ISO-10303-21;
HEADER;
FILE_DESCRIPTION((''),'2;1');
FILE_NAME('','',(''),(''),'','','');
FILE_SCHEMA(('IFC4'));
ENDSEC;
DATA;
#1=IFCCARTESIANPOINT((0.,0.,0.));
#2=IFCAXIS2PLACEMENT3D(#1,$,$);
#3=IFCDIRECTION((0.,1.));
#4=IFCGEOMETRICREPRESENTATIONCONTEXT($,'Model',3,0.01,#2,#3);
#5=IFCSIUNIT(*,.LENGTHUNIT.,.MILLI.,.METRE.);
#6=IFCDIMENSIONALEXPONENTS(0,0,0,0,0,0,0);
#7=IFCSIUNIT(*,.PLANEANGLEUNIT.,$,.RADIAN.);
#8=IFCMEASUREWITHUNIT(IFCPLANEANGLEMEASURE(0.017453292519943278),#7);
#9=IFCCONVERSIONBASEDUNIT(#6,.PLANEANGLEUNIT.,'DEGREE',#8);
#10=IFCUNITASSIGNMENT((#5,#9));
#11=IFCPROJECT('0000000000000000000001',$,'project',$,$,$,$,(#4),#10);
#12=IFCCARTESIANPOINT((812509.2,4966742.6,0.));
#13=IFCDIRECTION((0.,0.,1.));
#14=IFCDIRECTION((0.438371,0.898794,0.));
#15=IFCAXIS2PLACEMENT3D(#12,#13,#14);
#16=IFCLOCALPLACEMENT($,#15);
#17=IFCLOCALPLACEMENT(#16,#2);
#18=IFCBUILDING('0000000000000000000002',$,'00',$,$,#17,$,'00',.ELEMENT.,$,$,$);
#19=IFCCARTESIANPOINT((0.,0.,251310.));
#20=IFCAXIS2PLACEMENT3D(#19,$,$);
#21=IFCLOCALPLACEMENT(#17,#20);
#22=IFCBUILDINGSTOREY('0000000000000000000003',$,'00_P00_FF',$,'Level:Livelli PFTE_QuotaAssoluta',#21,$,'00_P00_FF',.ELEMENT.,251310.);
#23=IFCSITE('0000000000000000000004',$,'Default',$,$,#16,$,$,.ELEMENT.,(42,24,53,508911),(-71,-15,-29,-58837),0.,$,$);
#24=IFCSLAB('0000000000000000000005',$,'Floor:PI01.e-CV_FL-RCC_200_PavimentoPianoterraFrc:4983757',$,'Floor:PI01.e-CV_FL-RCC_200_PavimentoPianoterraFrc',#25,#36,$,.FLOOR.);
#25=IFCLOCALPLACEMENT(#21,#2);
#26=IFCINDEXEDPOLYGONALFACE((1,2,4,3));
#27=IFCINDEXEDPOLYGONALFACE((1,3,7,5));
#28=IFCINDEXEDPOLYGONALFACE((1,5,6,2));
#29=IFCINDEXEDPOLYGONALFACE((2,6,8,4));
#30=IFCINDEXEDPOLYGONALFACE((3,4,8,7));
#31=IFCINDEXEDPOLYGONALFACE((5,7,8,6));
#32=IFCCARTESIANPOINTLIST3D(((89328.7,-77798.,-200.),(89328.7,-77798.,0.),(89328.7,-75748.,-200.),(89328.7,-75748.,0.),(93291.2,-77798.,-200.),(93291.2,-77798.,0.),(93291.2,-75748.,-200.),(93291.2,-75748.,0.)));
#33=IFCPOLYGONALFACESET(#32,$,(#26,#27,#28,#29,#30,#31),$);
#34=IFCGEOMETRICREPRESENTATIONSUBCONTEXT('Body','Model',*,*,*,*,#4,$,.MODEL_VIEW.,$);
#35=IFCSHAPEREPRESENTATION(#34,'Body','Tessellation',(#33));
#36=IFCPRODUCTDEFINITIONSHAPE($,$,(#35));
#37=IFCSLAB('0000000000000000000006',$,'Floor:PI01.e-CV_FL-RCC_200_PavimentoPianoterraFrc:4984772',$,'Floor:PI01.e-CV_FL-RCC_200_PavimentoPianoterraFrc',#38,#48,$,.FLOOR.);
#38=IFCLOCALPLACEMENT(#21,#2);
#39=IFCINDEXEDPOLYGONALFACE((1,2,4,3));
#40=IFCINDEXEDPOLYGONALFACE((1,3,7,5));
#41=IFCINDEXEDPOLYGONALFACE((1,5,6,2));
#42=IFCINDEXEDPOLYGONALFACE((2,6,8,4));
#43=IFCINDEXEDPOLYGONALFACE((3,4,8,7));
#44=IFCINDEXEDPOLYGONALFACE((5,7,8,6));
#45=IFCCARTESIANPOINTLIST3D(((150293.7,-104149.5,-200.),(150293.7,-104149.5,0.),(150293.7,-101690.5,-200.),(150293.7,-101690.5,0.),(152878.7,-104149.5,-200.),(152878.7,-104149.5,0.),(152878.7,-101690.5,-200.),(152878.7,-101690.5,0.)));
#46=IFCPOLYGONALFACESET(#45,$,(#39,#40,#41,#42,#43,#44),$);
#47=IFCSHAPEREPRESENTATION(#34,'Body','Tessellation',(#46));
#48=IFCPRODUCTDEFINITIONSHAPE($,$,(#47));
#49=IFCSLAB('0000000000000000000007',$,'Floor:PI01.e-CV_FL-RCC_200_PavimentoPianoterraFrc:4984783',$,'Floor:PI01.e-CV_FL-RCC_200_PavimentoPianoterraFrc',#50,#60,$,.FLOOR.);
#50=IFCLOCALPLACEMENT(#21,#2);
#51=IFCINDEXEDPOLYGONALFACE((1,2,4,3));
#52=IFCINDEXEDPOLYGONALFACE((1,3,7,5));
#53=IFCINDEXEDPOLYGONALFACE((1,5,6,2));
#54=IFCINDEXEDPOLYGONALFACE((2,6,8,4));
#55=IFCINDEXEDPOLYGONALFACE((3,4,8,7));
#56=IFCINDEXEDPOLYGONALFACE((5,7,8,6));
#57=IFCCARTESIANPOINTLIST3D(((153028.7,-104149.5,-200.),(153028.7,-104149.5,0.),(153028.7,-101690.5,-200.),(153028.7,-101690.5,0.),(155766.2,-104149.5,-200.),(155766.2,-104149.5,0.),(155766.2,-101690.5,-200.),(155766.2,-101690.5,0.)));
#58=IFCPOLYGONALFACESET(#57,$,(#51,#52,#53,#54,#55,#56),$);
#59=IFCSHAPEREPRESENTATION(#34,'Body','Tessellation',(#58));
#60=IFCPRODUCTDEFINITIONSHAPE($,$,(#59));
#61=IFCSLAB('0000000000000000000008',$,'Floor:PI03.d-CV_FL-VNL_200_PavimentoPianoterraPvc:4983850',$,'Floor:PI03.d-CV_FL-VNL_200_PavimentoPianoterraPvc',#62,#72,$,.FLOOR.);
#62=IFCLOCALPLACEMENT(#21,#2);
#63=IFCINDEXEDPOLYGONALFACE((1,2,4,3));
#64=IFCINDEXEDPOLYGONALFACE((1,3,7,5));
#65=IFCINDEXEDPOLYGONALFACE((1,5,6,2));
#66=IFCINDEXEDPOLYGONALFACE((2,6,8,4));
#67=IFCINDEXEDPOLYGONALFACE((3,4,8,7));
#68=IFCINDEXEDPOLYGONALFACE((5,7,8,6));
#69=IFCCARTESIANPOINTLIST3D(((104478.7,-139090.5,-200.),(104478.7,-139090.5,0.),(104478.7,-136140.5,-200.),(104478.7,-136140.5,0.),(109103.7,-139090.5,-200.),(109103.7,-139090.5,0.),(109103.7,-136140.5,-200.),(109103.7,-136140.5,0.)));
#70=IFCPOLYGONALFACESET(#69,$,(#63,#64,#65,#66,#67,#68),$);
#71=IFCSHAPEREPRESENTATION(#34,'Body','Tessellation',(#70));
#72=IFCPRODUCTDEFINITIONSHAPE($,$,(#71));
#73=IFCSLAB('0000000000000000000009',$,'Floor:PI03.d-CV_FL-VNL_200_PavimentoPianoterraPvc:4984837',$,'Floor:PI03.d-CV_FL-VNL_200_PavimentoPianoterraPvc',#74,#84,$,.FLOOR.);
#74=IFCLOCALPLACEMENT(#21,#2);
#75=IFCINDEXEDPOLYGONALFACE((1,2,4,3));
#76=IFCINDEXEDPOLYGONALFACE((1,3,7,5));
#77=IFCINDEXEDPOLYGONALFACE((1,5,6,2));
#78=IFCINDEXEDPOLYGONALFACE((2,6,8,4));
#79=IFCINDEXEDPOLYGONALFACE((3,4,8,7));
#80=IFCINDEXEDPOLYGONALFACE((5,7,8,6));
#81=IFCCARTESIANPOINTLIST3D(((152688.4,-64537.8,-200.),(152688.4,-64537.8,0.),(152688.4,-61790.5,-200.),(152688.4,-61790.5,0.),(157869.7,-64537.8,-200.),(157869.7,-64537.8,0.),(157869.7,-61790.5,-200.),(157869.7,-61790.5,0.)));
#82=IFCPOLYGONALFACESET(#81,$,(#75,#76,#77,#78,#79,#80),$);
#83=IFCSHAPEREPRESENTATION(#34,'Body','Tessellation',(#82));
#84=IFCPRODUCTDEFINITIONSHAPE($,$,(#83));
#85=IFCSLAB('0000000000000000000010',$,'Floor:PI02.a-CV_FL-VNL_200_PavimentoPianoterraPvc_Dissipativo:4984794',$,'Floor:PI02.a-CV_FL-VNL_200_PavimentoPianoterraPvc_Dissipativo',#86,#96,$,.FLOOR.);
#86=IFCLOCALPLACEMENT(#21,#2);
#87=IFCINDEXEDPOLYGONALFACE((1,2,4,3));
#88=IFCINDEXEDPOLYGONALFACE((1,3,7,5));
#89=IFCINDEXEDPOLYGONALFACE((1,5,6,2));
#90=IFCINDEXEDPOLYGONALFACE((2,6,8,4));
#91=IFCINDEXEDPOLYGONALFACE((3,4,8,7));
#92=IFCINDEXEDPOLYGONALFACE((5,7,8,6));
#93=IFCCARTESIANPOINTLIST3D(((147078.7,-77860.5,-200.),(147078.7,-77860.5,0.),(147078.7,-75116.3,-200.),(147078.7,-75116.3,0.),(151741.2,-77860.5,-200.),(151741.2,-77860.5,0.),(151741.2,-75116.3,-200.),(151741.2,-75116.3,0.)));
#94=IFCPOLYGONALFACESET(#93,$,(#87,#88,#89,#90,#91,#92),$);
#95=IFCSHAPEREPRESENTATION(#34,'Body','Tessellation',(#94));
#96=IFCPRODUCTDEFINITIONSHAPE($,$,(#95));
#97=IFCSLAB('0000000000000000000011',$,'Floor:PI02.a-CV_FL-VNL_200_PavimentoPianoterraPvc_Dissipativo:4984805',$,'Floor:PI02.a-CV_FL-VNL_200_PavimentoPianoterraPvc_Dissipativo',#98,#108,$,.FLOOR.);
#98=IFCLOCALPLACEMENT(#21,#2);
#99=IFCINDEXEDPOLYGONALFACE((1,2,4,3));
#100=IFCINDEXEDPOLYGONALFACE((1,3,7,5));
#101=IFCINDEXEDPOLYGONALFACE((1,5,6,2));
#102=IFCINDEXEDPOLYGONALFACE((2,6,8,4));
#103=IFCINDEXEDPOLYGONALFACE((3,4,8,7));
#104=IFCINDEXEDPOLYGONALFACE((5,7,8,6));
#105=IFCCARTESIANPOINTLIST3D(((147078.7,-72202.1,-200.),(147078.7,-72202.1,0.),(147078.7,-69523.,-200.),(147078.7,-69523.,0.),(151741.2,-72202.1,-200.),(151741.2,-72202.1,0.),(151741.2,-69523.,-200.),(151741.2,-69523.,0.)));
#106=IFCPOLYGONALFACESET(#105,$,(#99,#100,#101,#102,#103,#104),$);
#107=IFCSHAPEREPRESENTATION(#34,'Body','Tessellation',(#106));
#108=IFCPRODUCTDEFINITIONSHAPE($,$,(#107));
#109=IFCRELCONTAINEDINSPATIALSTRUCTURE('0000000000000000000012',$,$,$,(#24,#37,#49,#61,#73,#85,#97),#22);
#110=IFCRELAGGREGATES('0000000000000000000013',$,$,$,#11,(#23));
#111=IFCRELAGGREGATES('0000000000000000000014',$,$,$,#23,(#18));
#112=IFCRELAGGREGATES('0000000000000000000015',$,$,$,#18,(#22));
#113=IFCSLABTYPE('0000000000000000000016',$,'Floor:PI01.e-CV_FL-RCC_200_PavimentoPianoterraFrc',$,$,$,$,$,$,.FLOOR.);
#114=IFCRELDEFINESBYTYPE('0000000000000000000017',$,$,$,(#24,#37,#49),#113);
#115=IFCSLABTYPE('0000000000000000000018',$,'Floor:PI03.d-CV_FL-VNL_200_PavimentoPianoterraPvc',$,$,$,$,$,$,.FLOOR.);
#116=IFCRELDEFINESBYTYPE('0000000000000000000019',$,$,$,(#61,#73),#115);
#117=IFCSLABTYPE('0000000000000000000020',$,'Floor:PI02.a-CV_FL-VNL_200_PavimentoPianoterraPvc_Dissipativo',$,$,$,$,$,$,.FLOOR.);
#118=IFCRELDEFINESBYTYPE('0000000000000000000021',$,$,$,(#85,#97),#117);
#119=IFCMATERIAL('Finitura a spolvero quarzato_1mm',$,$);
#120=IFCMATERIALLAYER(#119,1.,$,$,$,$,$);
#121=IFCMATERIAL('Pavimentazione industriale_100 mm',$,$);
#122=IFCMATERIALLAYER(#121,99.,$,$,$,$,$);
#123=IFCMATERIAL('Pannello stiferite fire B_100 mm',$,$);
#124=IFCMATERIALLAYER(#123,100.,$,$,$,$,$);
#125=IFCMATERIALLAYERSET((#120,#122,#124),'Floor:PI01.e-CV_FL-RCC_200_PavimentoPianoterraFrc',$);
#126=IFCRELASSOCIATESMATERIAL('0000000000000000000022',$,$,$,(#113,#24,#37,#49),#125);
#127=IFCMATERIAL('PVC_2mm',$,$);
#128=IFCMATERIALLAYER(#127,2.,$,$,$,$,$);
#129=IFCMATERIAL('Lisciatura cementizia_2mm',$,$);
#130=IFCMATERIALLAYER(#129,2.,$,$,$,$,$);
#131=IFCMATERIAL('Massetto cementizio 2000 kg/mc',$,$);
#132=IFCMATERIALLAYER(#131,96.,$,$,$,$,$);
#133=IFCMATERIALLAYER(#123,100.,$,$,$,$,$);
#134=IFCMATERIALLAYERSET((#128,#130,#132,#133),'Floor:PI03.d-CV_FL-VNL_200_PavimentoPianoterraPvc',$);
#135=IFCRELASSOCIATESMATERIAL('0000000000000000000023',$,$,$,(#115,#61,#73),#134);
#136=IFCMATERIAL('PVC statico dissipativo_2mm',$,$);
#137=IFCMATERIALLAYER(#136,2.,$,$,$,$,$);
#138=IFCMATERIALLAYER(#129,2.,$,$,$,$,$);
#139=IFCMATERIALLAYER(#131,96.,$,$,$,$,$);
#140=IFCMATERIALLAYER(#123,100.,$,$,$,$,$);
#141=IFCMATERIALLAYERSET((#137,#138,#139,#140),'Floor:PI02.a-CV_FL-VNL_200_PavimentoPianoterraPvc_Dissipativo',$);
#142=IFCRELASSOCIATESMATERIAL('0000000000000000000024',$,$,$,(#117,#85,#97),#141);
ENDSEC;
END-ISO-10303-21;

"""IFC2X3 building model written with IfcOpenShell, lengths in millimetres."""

from ifc_helpers import new_model, entity, si_unit, converted_unit, direction, frame, frame_2d, origin, origin_2d_with_axis, place, context, subcontext, project, spatial, rectangle, extrude, material, layer, layer_set, layer_usage, type_object, element, save


model = new_model("IFC2X3")

# Units and contexts
model_context = context("Model", 3, precision=0.01, world=origin(), true_north=direction((0.0, 1.0)))
body_context = subcontext(model_context, "Body", "Model", "MODEL_VIEW")
ifc_project = project(units=[si_unit("LENGTHUNIT", "METRE", prefix="MILLI"), converted_unit("PLANEANGLEUNIT", "DEGREE", entity("IfcPlaneAngleMeasure", 0.017453292519943278), si_unit("PLANEANGLEUNIT", "RADIAN"), dimensions=[0, 0, 0, 0, 0, 0, 0])], contexts=[model_context])

# Site, building, storey
site_placement = place(None, frame((812509.2, 4966742.6, 0.0), z_axis=(0.0, 0.0, 1.0), x_axis=(0.438371, 0.898794, 0.0)))
site = spatial("IfcSite", under=ifc_project, at=site_placement, Name="Default", CompositionType="ELEMENT", RefLatitude=(42, 24, 53, 508911), RefLongitude=(-71, -15, -29, -58837), RefElevation=0.0)
building_placement = place(site_placement, origin())
building = spatial("IfcBuilding", under=site, at=building_placement, Name="00", LongName="00", CompositionType="ELEMENT")
storey_placement = place(building_placement, frame((0.0, 0.0, 251310.0)))
storey = spatial("IfcBuildingStorey", under=building, at=storey_placement, Name="00_P00_FF", ObjectType="Level:Livelli PFTE_QuotaAssoluta", LongName="00_P00_FF", CompositionType="ELEMENT", Elevation=251310.0)

# Slabs
ifc_material_1 = material(Name="Massetto cementizio 2000 kg/mc")
ifc_material_2 = material(Name="Pannello stiferite fire B_100 mm")
ifc_material_3 = material(Name="Finitura a spolvero quarzato_1mm")
ifc_layer_1 = layer(ifc_material_3, 1.0)
ifc_material_4 = material(Name="Pavimentazione industriale_100 mm")
ifc_layer_2 = layer(ifc_material_4, 99.0)
ifc_layer_3 = layer(ifc_material_2, 100.0)
ifc_layer_set_1 = layer_set([ifc_layer_1, ifc_layer_2, ifc_layer_3], Name="Floor:PI01.e-CV_FL-RCC_200_PavimentoPianoterraFrc")
ifc_layer_usage_1 = layer_usage(ifc_layer_set_1, "AXIS3", "POSITIVE", 0.0)
slab_type_1 = type_object("IfcSlabType", Name="Floor:PI01.e-CV_FL-RCC_200_PavimentoPianoterraFrc", PredefinedType="FLOOR", material=ifc_layer_set_1)
slab_1_placement = place(storey_placement, origin())
element("IfcSlab", 1, at=slab_1_placement, inside=storey, type_object=slab_type_1, material=ifc_layer_usage_1, Name="Floor:PI01.e-CV_FL-RCC_200_PavimentoPianoterraFrc:4983757", ObjectType="Floor:PI01.e-CV_FL-RCC_200_PavimentoPianoterraFrc", PredefinedType="FLOOR", context=body_context, shape_type="SweptSolid", body=[
    extrude(rectangle(XDim=2050.0, YDim=3962.5, at=frame_2d((0.0, 0.0), x_axis=(1.0, 0.0))), frame((91309.9, -76773.0, 0.0), z_axis=(0.0, 0.0, -1.0), x_axis=(0.0, 1.0, 0.0)), (0.0, 0.0, 1.0), 200.0),
])
ifc_layer_usage_2 = layer_usage(ifc_layer_set_1, "AXIS3", "POSITIVE", 0.0)
slab_2_placement = place(storey_placement, origin())
element("IfcSlab", 2, at=slab_2_placement, inside=storey, type_object=slab_type_1, material=ifc_layer_usage_2, Name="Floor:PI01.e-CV_FL-RCC_200_PavimentoPianoterraFrc:4984772", ObjectType="Floor:PI01.e-CV_FL-RCC_200_PavimentoPianoterraFrc", PredefinedType="FLOOR", context=body_context, shape_type="SweptSolid", body=[
    extrude(rectangle(XDim=2459.0, YDim=2585.0, at=frame_2d((0.0, 0.0), x_axis=(1.0, 0.0))), frame((151586.2, -102920.0, 0.0), z_axis=(0.0, 0.0, -1.0), x_axis=(0.0, 1.0, 0.0)), (0.0, 0.0, 1.0), 200.0),
])
ifc_layer_usage_3 = layer_usage(ifc_layer_set_1, "AXIS3", "POSITIVE", 0.0)
slab_3_placement = place(storey_placement, origin())
element("IfcSlab", 3, at=slab_3_placement, inside=storey, type_object=slab_type_1, material=ifc_layer_usage_3, Name="Floor:PI01.e-CV_FL-RCC_200_PavimentoPianoterraFrc:4984783", ObjectType="Floor:PI01.e-CV_FL-RCC_200_PavimentoPianoterraFrc", PredefinedType="FLOOR", context=body_context, shape_type="SweptSolid", body=[
    extrude(rectangle(XDim=2459.0, YDim=2737.5, at=frame_2d((0.0, 0.0), x_axis=(1.0, 0.0))), frame((154397.4, -102920.0, 0.0), z_axis=(0.0, 0.0, -1.0), x_axis=(0.0, 1.0, 0.0)), (0.0, 0.0, 1.0), 200.0),
])
ifc_material_5 = material(Name="PVC_2mm")
ifc_layer_4 = layer(ifc_material_5, 2.0)
ifc_material_6 = material(Name="Lisciatura cementizia_2mm")
ifc_layer_5 = layer(ifc_material_6, 2.0)
ifc_layer_6 = layer(ifc_material_1, 96.0)
ifc_layer_7 = layer(ifc_material_2, 100.0)
ifc_layer_set_2 = layer_set([ifc_layer_4, ifc_layer_5, ifc_layer_6, ifc_layer_7], Name="Floor:PI03.d-CV_FL-VNL_200_PavimentoPianoterraPvc")
ifc_layer_usage_4 = layer_usage(ifc_layer_set_2, "AXIS3", "POSITIVE", 0.0)
slab_type_2 = type_object("IfcSlabType", Name="Floor:PI03.d-CV_FL-VNL_200_PavimentoPianoterraPvc", PredefinedType="FLOOR", material=ifc_layer_set_2)
slab_4_placement = place(storey_placement, origin())
element("IfcSlab", 4, at=slab_4_placement, inside=storey, type_object=slab_type_2, material=ifc_layer_usage_4, Name="Floor:PI03.d-CV_FL-VNL_200_PavimentoPianoterraPvc:4983850", ObjectType="Floor:PI03.d-CV_FL-VNL_200_PavimentoPianoterraPvc", PredefinedType="FLOOR", context=body_context, shape_type="SweptSolid", body=[
    extrude(rectangle(XDim=2950.0, YDim=4625.0, at=frame_2d((0.0, 0.0), x_axis=(1.0, 0.0))), frame((106791.2, -137615.5, 0.0), z_axis=(0.0, 0.0, -1.0), x_axis=(0.0, 1.0, 0.0)), (0.0, 0.0, 1.0), 200.0),
])
ifc_layer_usage_5 = layer_usage(ifc_layer_set_2, "AXIS3", "POSITIVE", 0.0)
slab_5_placement = place(storey_placement, origin())
element("IfcSlab", 5, at=slab_5_placement, inside=storey, type_object=slab_type_2, material=ifc_layer_usage_5, Name="Floor:PI03.d-CV_FL-VNL_200_PavimentoPianoterraPvc:4984837", ObjectType="Floor:PI03.d-CV_FL-VNL_200_PavimentoPianoterraPvc", PredefinedType="FLOOR", context=body_context, shape_type="SweptSolid", body=[
    extrude(rectangle(XDim=2747.4, YDim=5181.2, at=frame_2d((0.0, 0.0), x_axis=(1.0, 0.0))), frame((155279.0, -63164.2, 0.0), z_axis=(0.0, 0.0, -1.0), x_axis=(0.0, 1.0, 0.0)), (0.0, 0.0, 1.0), 200.0),
])

# Slabs
ifc_material_7 = material(Name="PVC statico dissipativo_2mm")
ifc_layer_8 = layer(ifc_material_7, 2.0)
ifc_layer_9 = layer(ifc_material_6, 2.0)
ifc_layer_10 = layer(ifc_material_1, 96.0)
ifc_layer_11 = layer(ifc_material_2, 100.0)
ifc_layer_set_3 = layer_set([ifc_layer_8, ifc_layer_9, ifc_layer_10, ifc_layer_11], Name="Floor:PI02.a-CV_FL-VNL_200_PavimentoPianoterraPvc_Dissipativo")
ifc_layer_usage_6 = layer_usage(ifc_layer_set_3, "AXIS3", "POSITIVE", 0.0)
slab_type_3 = type_object("IfcSlabType", Name="Floor:PI02.a-CV_FL-VNL_200_PavimentoPianoterraPvc_Dissipativo", PredefinedType="FLOOR", material=ifc_layer_set_3)
slab_6_placement = place(storey_placement, origin())
element("IfcSlab", 6, at=slab_6_placement, inside=storey, type_object=slab_type_3, material=ifc_layer_usage_6, Name="Floor:PI02.a-CV_FL-VNL_200_PavimentoPianoterraPvc_Dissipativo:4984794", ObjectType="Floor:PI02.a-CV_FL-VNL_200_PavimentoPianoterraPvc_Dissipativo", PredefinedType="FLOOR", context=body_context, shape_type="SweptSolid", body=[
    extrude(rectangle(XDim=2744.2, YDim=4662.5, at=frame_2d((0.0, 0.0), x_axis=(1.0, 0.0))), frame((149409.9, -76488.4, 0.0), z_axis=(0.0, 0.0, -1.0), x_axis=(0.0, 1.0, 0.0)), (0.0, 0.0, 1.0), 200.0),
])
ifc_layer_usage_7 = layer_usage(ifc_layer_set_3, "AXIS3", "POSITIVE", 0.0)
slab_7_placement = place(storey_placement, origin())
element("IfcSlab", 7, at=slab_7_placement, inside=storey, type_object=slab_type_3, material=ifc_layer_usage_7, Name="Floor:PI02.a-CV_FL-VNL_200_PavimentoPianoterraPvc_Dissipativo:4984805", ObjectType="Floor:PI02.a-CV_FL-VNL_200_PavimentoPianoterraPvc_Dissipativo", PredefinedType="FLOOR", context=body_context, shape_type="SweptSolid", body=[
    extrude(rectangle(XDim=2679.2, YDim=4662.5, at=origin_2d_with_axis()), frame((149409.9, -70862.6, 0.0), z_axis=(0.0, 0.0, -1.0), x_axis=(0.0, 1.0, 0.0)), (0.0, 0.0, 1.0), 200.0),
])

save(model, "model.ifc")
